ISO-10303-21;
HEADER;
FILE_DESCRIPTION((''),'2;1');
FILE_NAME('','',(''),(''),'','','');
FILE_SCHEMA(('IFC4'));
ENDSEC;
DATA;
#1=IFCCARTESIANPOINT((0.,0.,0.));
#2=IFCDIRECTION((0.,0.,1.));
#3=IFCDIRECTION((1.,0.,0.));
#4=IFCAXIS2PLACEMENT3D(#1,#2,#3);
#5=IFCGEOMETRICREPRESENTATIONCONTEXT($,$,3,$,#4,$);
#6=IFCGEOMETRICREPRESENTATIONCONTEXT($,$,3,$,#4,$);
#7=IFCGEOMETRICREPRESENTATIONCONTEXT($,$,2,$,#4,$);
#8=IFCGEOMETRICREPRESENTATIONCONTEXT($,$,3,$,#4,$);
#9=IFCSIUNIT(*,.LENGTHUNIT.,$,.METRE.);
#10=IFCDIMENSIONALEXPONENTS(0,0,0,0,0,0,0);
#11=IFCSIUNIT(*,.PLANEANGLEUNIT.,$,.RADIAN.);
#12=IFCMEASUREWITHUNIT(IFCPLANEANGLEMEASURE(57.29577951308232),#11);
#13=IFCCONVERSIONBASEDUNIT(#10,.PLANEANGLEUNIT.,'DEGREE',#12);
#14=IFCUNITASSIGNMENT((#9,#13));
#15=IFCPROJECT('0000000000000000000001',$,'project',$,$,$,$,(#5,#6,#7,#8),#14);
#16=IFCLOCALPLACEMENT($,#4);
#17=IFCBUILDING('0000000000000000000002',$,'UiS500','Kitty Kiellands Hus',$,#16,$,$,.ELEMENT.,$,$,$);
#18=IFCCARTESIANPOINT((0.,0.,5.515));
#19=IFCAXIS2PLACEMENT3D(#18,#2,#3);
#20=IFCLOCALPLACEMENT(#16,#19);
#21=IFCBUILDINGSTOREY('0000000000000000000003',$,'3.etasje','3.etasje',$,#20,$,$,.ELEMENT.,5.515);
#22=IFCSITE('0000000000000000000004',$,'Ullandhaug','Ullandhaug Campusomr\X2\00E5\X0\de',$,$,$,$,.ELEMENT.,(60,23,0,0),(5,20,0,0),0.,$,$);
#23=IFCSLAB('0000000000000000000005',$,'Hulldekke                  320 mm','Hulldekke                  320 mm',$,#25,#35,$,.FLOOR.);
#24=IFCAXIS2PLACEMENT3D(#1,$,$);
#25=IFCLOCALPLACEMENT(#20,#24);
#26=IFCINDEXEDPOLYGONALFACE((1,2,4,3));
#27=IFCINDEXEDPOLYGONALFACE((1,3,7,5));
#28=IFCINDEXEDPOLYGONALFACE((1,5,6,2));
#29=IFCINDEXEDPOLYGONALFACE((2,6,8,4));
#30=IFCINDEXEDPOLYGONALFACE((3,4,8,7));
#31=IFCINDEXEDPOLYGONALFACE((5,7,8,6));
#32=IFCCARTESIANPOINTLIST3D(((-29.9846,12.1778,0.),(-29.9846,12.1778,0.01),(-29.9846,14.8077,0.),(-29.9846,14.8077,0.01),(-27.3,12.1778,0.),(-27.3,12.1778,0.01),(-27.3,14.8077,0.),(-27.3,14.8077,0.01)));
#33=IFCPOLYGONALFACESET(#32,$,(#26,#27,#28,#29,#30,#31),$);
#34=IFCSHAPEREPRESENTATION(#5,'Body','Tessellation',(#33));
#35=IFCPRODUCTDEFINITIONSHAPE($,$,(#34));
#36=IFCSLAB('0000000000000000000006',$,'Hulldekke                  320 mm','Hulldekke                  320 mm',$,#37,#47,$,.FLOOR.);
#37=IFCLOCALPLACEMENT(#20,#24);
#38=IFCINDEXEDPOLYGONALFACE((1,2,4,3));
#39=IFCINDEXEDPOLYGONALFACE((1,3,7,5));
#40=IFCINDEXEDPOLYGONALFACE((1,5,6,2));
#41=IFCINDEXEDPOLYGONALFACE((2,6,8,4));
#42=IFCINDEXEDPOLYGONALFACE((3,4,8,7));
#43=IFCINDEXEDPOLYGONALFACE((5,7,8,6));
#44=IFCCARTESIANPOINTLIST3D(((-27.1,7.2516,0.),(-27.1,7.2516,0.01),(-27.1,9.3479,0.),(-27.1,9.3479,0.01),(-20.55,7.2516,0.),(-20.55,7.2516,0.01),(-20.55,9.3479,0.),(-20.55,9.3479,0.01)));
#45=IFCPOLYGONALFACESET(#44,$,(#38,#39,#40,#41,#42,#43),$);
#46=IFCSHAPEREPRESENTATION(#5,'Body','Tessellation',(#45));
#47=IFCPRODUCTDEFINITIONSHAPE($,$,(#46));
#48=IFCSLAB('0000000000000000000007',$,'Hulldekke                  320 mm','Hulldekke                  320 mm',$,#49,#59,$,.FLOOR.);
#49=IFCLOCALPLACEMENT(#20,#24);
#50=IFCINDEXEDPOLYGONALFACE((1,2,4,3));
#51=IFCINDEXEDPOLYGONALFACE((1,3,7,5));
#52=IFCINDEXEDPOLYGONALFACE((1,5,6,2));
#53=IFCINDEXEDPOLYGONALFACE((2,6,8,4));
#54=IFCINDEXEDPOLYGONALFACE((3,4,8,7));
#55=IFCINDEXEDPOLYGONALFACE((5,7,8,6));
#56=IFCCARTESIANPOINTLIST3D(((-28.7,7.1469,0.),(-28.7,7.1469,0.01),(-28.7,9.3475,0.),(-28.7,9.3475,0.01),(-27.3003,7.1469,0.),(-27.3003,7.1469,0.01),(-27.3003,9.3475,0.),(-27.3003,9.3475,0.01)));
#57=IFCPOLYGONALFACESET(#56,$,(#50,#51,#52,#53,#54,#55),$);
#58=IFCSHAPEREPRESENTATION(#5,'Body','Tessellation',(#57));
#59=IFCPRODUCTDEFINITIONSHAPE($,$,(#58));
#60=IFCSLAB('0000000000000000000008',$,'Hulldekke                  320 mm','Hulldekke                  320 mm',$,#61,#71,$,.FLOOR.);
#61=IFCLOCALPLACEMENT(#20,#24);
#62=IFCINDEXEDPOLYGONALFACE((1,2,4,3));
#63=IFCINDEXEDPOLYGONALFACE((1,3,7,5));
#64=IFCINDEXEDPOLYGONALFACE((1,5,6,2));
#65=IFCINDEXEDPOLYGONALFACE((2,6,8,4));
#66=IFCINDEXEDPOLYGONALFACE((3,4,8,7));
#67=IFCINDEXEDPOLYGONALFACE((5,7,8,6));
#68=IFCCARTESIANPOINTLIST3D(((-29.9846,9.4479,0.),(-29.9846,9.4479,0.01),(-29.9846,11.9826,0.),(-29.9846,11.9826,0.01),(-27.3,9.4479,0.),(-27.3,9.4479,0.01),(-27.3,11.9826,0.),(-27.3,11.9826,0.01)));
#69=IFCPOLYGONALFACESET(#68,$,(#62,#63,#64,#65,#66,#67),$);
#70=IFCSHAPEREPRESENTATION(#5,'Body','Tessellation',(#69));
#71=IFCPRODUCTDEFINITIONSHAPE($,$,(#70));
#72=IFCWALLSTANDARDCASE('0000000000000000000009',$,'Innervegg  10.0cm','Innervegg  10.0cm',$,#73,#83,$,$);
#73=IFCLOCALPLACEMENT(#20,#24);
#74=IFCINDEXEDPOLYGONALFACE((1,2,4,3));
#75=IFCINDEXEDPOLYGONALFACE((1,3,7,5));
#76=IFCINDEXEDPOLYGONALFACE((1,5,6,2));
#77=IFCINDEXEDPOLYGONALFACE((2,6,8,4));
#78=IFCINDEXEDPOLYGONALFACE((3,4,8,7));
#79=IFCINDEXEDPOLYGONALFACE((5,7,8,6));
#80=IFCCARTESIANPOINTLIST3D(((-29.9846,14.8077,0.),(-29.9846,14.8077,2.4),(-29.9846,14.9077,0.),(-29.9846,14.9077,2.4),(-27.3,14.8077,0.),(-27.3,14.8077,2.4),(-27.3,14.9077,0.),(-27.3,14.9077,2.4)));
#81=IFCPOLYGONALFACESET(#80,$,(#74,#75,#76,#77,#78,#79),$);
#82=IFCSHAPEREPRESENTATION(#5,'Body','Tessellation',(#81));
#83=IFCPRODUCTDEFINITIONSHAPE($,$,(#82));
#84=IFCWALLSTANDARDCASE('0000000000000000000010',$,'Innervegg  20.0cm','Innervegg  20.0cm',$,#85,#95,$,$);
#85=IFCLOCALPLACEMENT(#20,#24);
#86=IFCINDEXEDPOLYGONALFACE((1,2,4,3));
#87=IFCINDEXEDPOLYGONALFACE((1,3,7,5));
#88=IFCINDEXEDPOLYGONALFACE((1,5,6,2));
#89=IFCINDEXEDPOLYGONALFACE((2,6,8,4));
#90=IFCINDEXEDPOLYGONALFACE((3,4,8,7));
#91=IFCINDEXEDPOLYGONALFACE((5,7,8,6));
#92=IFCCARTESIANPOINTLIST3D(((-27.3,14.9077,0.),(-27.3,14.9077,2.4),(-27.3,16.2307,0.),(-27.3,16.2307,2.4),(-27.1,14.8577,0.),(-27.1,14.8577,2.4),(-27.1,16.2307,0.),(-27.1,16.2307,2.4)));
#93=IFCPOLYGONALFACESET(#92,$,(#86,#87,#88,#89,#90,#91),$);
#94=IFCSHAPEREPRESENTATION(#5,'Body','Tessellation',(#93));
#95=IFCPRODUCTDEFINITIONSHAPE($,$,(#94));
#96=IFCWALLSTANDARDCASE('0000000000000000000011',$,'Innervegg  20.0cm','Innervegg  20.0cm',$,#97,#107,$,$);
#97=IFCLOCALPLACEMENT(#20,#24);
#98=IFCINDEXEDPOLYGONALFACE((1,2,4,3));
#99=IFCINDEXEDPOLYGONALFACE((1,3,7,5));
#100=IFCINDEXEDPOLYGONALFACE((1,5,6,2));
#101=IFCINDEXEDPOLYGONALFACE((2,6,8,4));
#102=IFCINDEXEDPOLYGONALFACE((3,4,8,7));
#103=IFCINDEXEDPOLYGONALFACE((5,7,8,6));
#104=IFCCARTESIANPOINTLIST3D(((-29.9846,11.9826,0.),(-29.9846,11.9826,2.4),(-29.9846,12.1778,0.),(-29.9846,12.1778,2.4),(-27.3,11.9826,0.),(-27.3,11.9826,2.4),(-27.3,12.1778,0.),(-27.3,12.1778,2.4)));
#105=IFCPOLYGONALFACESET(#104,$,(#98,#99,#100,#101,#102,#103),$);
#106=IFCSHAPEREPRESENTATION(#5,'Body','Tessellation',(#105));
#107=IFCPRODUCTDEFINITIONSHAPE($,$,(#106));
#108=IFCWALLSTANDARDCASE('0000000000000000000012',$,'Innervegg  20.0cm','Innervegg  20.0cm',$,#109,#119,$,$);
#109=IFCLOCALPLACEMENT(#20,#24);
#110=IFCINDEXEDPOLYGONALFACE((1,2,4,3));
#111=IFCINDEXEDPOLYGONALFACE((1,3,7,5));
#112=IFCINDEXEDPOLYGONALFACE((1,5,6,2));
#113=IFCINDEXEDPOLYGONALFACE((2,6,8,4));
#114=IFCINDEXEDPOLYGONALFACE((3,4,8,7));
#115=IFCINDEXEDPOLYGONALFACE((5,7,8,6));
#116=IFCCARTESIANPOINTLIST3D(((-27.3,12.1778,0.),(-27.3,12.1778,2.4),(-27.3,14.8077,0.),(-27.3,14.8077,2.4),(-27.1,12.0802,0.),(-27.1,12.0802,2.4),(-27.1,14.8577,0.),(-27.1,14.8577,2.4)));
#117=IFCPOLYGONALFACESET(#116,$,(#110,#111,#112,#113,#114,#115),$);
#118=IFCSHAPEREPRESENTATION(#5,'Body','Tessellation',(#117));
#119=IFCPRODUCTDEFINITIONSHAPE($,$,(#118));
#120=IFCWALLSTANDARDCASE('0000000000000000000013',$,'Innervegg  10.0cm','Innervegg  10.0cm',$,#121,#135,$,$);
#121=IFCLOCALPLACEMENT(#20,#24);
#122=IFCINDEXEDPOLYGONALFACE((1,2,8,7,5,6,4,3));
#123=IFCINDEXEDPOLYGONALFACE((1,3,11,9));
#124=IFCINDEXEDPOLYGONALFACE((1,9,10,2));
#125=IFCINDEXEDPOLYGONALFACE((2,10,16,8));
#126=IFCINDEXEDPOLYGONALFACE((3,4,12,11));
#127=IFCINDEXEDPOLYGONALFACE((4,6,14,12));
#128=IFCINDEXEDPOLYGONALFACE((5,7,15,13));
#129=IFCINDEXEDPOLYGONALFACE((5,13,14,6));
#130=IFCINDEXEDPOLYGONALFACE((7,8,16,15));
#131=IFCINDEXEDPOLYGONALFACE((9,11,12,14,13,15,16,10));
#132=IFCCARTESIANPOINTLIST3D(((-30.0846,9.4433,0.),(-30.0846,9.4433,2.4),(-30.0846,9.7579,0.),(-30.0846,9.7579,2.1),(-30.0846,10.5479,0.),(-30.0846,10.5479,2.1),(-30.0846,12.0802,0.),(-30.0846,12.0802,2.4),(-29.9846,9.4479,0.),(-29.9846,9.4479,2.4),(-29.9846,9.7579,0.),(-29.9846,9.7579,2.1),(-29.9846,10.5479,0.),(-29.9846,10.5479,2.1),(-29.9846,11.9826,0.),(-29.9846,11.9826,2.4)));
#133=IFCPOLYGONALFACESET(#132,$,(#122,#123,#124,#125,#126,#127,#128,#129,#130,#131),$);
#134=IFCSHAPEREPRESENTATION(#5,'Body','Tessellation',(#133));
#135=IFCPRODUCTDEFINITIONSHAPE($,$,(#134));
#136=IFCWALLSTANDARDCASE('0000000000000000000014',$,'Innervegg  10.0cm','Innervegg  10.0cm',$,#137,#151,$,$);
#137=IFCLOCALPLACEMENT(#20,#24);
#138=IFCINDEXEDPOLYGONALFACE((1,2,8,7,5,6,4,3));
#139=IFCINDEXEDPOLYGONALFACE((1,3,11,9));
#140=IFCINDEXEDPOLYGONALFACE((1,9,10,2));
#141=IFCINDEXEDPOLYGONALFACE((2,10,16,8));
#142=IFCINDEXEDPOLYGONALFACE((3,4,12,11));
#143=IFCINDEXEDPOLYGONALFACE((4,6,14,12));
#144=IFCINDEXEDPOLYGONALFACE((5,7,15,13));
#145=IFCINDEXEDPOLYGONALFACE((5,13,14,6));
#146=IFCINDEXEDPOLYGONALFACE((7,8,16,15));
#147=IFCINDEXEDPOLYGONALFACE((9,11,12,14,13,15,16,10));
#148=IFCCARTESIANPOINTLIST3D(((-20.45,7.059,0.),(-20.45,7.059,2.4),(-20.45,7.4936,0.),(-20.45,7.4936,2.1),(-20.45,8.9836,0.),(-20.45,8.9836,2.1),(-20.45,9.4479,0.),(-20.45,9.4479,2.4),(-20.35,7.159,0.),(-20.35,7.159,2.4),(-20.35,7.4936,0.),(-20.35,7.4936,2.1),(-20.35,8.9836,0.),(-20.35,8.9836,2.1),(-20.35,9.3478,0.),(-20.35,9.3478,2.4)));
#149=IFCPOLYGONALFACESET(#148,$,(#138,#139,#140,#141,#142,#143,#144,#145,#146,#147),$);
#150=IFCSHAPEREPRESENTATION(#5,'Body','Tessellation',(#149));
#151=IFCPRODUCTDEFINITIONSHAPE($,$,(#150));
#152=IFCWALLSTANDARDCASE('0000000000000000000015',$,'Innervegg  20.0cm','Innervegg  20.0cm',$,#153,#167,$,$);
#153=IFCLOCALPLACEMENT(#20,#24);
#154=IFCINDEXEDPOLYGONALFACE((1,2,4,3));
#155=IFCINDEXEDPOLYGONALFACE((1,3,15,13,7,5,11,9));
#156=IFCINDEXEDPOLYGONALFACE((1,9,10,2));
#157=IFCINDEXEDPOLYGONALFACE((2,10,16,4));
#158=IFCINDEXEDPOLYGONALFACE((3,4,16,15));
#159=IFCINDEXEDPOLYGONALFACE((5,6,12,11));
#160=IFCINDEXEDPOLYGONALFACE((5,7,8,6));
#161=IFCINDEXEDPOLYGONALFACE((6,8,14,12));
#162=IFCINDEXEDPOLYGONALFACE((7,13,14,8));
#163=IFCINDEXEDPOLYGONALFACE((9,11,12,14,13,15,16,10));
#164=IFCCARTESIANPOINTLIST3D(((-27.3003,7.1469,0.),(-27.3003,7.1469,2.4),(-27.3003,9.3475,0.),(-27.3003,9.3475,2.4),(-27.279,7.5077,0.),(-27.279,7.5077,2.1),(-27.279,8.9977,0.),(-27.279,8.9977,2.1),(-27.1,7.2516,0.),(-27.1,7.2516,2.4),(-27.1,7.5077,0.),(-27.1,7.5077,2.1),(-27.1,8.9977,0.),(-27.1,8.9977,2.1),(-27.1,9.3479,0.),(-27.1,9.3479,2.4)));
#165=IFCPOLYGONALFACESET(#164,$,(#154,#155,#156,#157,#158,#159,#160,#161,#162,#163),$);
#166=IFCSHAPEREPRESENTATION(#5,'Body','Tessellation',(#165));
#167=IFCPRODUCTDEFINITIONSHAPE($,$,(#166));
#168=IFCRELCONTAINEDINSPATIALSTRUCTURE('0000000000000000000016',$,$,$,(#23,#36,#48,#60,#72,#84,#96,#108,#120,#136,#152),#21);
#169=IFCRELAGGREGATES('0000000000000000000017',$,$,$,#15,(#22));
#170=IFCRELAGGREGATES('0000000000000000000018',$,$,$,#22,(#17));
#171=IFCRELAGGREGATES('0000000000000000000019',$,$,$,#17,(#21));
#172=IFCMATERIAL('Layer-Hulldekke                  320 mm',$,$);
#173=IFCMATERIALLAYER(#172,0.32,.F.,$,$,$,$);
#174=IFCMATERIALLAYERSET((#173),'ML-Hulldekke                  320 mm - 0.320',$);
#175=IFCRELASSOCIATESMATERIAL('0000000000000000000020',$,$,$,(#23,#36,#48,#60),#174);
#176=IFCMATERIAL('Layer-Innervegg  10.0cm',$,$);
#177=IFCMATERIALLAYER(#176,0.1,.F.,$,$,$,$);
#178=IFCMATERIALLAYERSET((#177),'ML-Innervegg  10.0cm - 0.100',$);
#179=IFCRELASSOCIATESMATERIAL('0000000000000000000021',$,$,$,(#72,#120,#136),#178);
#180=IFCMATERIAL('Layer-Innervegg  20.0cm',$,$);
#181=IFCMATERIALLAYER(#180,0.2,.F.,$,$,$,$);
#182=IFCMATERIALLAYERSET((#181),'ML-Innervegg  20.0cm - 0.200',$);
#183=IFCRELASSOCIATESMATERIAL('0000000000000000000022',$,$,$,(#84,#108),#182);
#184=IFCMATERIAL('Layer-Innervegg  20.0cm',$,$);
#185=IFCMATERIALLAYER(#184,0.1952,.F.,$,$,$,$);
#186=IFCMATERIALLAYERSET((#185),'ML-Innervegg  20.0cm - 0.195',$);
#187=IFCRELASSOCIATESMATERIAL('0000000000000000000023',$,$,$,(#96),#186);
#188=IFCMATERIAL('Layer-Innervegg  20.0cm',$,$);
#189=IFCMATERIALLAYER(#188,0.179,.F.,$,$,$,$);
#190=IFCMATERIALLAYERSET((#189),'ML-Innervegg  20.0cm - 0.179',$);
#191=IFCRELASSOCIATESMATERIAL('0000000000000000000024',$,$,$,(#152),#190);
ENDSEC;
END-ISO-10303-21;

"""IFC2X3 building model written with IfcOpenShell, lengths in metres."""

from ifc_helpers import new_model, entity, si_unit, converted_unit, frame, origin_with_axes, place, context, project, spatial, polyline, outline, extrude, material, layer, layer_set, layer_usage, element, save


model = new_model("IFC2X3")

# Units and contexts
context_of_model_1 = context(None, 3, world=origin_with_axes())
context_of_model_2 = context(None, 3, world=origin_with_axes())
context_of_model_3 = context(None, 2, world=origin_with_axes())
context_of_model_4 = context(None, 3, world=origin_with_axes())
ifc_project = project(units=[si_unit("LENGTHUNIT", "METRE"), converted_unit("PLANEANGLEUNIT", "DEGREE", entity("IfcPlaneAngleMeasure", 57.29577951308232), si_unit("PLANEANGLEUNIT", "RADIAN"), dimensions=[0, 0, 0, 0, 0, 0, 0])], contexts=[context_of_model_1, context_of_model_2, context_of_model_3, context_of_model_4])

# Site, building, storey
site = spatial("IfcSite", under=ifc_project, Name="Ullandhaug", Description="Ullandhaug Campusområde", CompositionType="ELEMENT", RefLatitude=(60, 23, 0, 0), RefLongitude=(5, 20, 0, 0), RefElevation=0.0)
building_placement = place(None, origin_with_axes())
building = spatial("IfcBuilding", under=site, at=building_placement, Name="UiS500", Description="Kitty Kiellands Hus", CompositionType="ELEMENT")
storey_placement = place(building_placement, frame((0.0, 0.0, 5.515), z_axis=(0.0, 0.0, 1.0), x_axis=(1.0, 0.0, 0.0)))
storey = spatial("IfcBuildingStorey", under=building, at=storey_placement, Name="3.etasje", Description="3.etasje", CompositionType="ELEMENT", Elevation=5.515)

# Slabs
ifc_material_1 = material(Name="Layer-Hulldekke                  320 mm")
ifc_layer_1 = layer(ifc_material_1, 0.32, ventilated=False)
ifc_layer_set_1 = layer_set([ifc_layer_1], Name="ML-Hulldekke                  320 mm - 0.320")
ifc_layer_usage_1 = layer_usage(ifc_layer_set_1, "AXIS2", "POSITIVE", 0.0)
slab_1_placement = place(storey_placement, frame((-29.9846, 14.8077, 0.0), z_axis=(0.0, 0.0, 1.0), x_axis=(1.0, 0.0, 0.0)))
element("IfcSlab", 1, at=slab_1_placement, inside=storey, material=ifc_layer_usage_1, Name="Hulldekke                  320 mm", Description="Hulldekke                  320 mm", PredefinedType="FLOOR", context=context_of_model_1, shape_type="SweptSolid", body=[
    extrude(outline(polyline([(0.0, 0.0), (2.6299, 0.0), (2.6299, 2.6846), (0.0, 2.6846), (0.0, 0.0)])), frame((0.0, 0.0, 0.0), z_axis=(0.0, 0.0, 1.0), x_axis=(0.0, -1.0, 0.0)), (0.0, 0.0, 1.0), 0.01),
])
slab_2_placement = place(storey_placement, frame((-27.1, 9.3479, 0.0), z_axis=(0.0, 0.0, 1.0), x_axis=(1.0, 0.0, 0.0)))
element("IfcSlab", 2, at=slab_2_placement, inside=storey, material=ifc_layer_usage_1, Name="Hulldekke                  320 mm", Description="Hulldekke                  320 mm", PredefinedType="FLOOR", context=context_of_model_1, shape_type="SweptSolid", body=[
    extrude(outline(polyline([(0.0, 0.0), (2.0963, 0.0), (2.0963, 6.55), (0.0, 6.55), (0.0, 0.0)])), frame((0.0, 0.0, 0.0), z_axis=(0.0, 0.0, 1.0), x_axis=(0.0, -1.0, 0.0)), (0.0, 0.0, 1.0), 0.01),
])
slab_3_placement = place(storey_placement, frame((-28.7, 9.3475, 0.0), z_axis=(0.0, 0.0, 1.0), x_axis=(1.0, 0.0, 0.0)))
element("IfcSlab", 3, at=slab_3_placement, inside=storey, material=ifc_layer_usage_1, Name="Hulldekke                  320 mm", Description="Hulldekke                  320 mm", PredefinedType="FLOOR", context=context_of_model_1, shape_type="SweptSolid", body=[
    extrude(outline(polyline([(0.0, 0.0), (2.2006, 0.0), (2.2006, 1.3997), (0.0, 1.3997), (0.0, 0.0)])), frame((0.0, 0.0, 0.0), z_axis=(0.0, 0.0, 1.0), x_axis=(0.0, -1.0, 0.0)), (0.0, 0.0, 1.0), 0.01),
])
slab_4_placement = place(storey_placement, frame((-29.9846, 11.9826, 0.0), z_axis=(0.0, 0.0, 1.0), x_axis=(1.0, 0.0, 0.0)))
element("IfcSlab", 4, at=slab_4_placement, inside=storey, material=ifc_layer_usage_1, Name="Hulldekke                  320 mm", Description="Hulldekke                  320 mm", PredefinedType="FLOOR", context=context_of_model_1, shape_type="SweptSolid", body=[
    extrude(outline(polyline([(0.0, 0.0), (2.5347, 0.0), (2.5347, 2.6846), (0.0, 2.6846), (0.0, 0.0)])), frame((0.0, 0.0, 0.0), z_axis=(0.0, 0.0, 1.0), x_axis=(0.0, -1.0, 0.0)), (0.0, 0.0, 1.0), 0.01),
])

# Walls
ifc_material_2 = material(Name="Layer-Innervegg  10.0cm")
ifc_layer_2 = layer(ifc_material_2, 0.1, ventilated=False)
ifc_layer_set_2 = layer_set([ifc_layer_2], Name="ML-Innervegg  10.0cm - 0.100")
ifc_layer_usage_2 = layer_usage(ifc_layer_set_2, "AXIS2", "POSITIVE", 0.0)
wall_1_placement = place(storey_placement, frame((-29.9846, 14.8077, 0.0), z_axis=(0.0, 0.0, 1.0), x_axis=(1.0, 0.0, 0.0)))
element("IfcWallStandardCase", 5, at=wall_1_placement, inside=storey, material=ifc_layer_usage_2, Name="Innervegg  10.0cm", Description="Innervegg  10.0cm", context=context_of_model_1, shape_type="SweptSolid", body=[
    extrude(outline(polyline([(0.0, 0.0), (2.6846, 0.0), (2.6846, 0.1), (0.0, 0.1), (0.0, 0.0)])), origin_with_axes(), (0.0, 0.0, 1.0), 2.4),
])
ifc_material_3 = material(Name="Layer-Innervegg  20.0cm")
ifc_layer_3 = layer(ifc_material_3, 0.2, ventilated=False)
ifc_layer_set_3 = layer_set([ifc_layer_3], Name="ML-Innervegg  20.0cm - 0.200")
ifc_layer_usage_3 = layer_usage(ifc_layer_set_3, "AXIS2", "POSITIVE", 0.0)
wall_2_placement = place(storey_placement, frame((-27.1, 14.8577, 0.0), z_axis=(0.0, 0.0, 1.0), x_axis=(0.0, 1.0, 0.0)))
element("IfcWallStandardCase", 6, at=wall_2_placement, inside=storey, material=ifc_layer_usage_3, Name="Innervegg  20.0cm", Description="Innervegg  20.0cm", context=context_of_model_1, shape_type="SweptSolid", body=[
    extrude(outline(polyline([(0.0, 0.0), (1.373, 0.0), (1.373, 0.2), (0.05, 0.2), (0.0, 0.0)])), frame((0.0, 0.0, 0.0), z_axis=(0.0, 0.0, 1.0), x_axis=(1.0, 0.0, 0.0)), (0.0, 0.0, 1.0), 2.4),
])
ifc_material_4 = material(Name="Layer-Innervegg  20.0cm")
ifc_layer_4 = layer(ifc_material_4, 0.1952, ventilated=False)
ifc_layer_set_4 = layer_set([ifc_layer_4], Name="ML-Innervegg  20.0cm - 0.195")
ifc_layer_usage_4 = layer_usage(ifc_layer_set_4, "AXIS2", "POSITIVE", 0.0)
wall_3_placement = place(storey_placement, frame((-29.9846, 11.9826, 0.0), z_axis=(0.0, 0.0, 1.0), x_axis=(1.0, 0.0, 0.0)))
element("IfcWallStandardCase", 7, at=wall_3_placement, inside=storey, material=ifc_layer_usage_4, Name="Innervegg  20.0cm", Description="Innervegg  20.0cm", context=context_of_model_1, shape_type="SweptSolid", body=[
    extrude(outline(polyline([(0.0, 0.0), (2.6846, 0.0), (2.6846, 0.1952), (0.0, 0.1952), (0.0, 0.0)])), origin_with_axes(), (0.0, 0.0, 1.0), 2.4),
])
wall_4_placement = place(storey_placement, frame((-27.1, 12.0802, 0.0), z_axis=(0.0, 0.0, 1.0), x_axis=(0.0, 1.0, 0.0)))
element("IfcWallStandardCase", 8, at=wall_4_placement, inside=storey, material=ifc_layer_usage_3, Name="Innervegg  20.0cm", Description="Innervegg  20.0cm", context=context_of_model_1, shape_type="SweptSolid", body=[
    extrude(outline(polyline([(0.0, 0.0), (2.7775, 0.0), (2.7275, 0.2), (0.0976, 0.2), (0.0, 0.0)])), frame((0.0, 0.0, 0.0), z_axis=(0.0, 0.0, 1.0), x_axis=(1.0, 0.0, 0.0)), (0.0, 0.0, 1.0), 2.4),
])

# Walls, openings
wall_5_placement = place(storey_placement, frame((-29.9846, 9.4479, 0.0), z_axis=(0.0, 0.0, 1.0), x_axis=(0.0, 1.0, 0.0)))
wall_5 = element("IfcWallStandardCase", 9, at=wall_5_placement, inside=storey, material=ifc_layer_usage_2, Name="Innervegg  10.0cm", Description="Innervegg  10.0cm", context=context_of_model_1, shape_type="SweptSolid", body=[
    extrude(outline(polyline([(0.0, 0.0), (2.5347, 0.0), (2.6323, 0.1), (-0.0047, 0.1), (0.0, 0.0)])), frame((0.0, 0.0, 0.0), z_axis=(0.0, 0.0, 1.0), x_axis=(1.0, 0.0, 0.0)), (0.0, 0.0, 1.0), 2.4),
])
opening_1_placement = place(wall_5_placement, frame((0.3099, 0.1, 0.0), z_axis=(0.0, 0.0, 1.0), x_axis=(1.0, 0.0, 0.0)))
element("IfcOpeningElement", 10, at=opening_1_placement, cuts=wall_5, context=context_of_model_1, shape_type="SweptSolid", body=[
    extrude(outline(polyline([(0.0, 0.0), (2.1, 0.0), (2.1, 0.79), (0.0, 0.79), (0.0, 0.0)])), frame((0.0, 0.0, 0.0), z_axis=(0.0, 1.0, 0.0), x_axis=(0.0, 0.0, 1.0)), (0.0, 0.0, -1.0), 0.1),
])
wall_6_placement = place(storey_placement, frame((-20.45, 9.4479, 0.0), z_axis=(0.0, 0.0, 1.0), x_axis=(0.0, -1.0, 0.0)))
wall_6 = element("IfcWallStandardCase", 11, at=wall_6_placement, inside=storey, material=ifc_layer_usage_2, Name="Innervegg  10.0cm", Description="Innervegg  10.0cm", context=context_of_model_1, shape_type="SweptSolid", body=[
    extrude(outline(polyline([(0.0, 0.0), (2.3889, 0.0), (2.2889, 0.1), (0.1002, 0.1), (0.0, 0.0)])), frame((0.0, 0.0, 0.0), z_axis=(0.0, 0.0, 1.0), x_axis=(1.0, 0.0, 0.0)), (0.0, 0.0, 1.0), 2.4),
])
opening_2_placement = place(wall_6_placement, frame((0.4644, 0.1, 0.0), z_axis=(0.0, 0.0, 1.0), x_axis=(1.0, 0.0, 0.0)))
element("IfcOpeningElement", 12, at=opening_2_placement, cuts=wall_6, context=context_of_model_1, shape_type="SweptSolid", body=[
    extrude(outline(polyline([(0.0, 0.0), (2.1, 0.0), (2.1, 1.49), (0.0, 1.49), (0.0, 0.0)])), frame((0.0, 0.0, 0.0), z_axis=(0.0, 1.0, 0.0), x_axis=(0.0, 0.0, 1.0)), (0.0, 0.0, -1.0), 0.1),
])
ifc_material_5 = material(Name="Layer-Innervegg  20.0cm")
ifc_layer_5 = layer(ifc_material_5, 0.179, ventilated=False)
ifc_layer_set_5 = layer_set([ifc_layer_5], Name="ML-Innervegg  20.0cm - 0.179")
ifc_layer_usage_5 = layer_usage(ifc_layer_set_5, "AXIS2", "POSITIVE", 0.0)
wall_7_placement = place(storey_placement, frame((-27.3003, 9.3475, 0.0), z_axis=(0.0, 0.0, 1.0), x_axis=(0.0, -1.0, 0.0)))
wall_7 = element("IfcWallStandardCase", 13, at=wall_7_placement, inside=storey, material=ifc_layer_usage_5, Name="Innervegg  20.0cm", Description="Innervegg  20.0cm", context=context_of_model_1, shape_type="SweptSolid", body=[
    extrude(outline(polyline([(0.0, 0.0), (2.2006, 0.0), (2.0959, 0.2003), (-0.0004, 0.2003), (0.0, 0.0)])), frame((0.0, 0.0, 0.0), z_axis=(0.0, 0.0, 1.0), x_axis=(1.0, 0.0, 0.0)), (0.0, 0.0, 1.0), 2.4),
])
opening_3_placement = place(wall_7_placement, frame((0.3498, 0.2003, 0.0), z_axis=(0.0, 0.0, 1.0), x_axis=(1.0, 0.0, 0.0)))
element("IfcOpeningElement", 14, at=opening_3_placement, cuts=wall_7, context=context_of_model_1, shape_type="SweptSolid", body=[
    extrude(outline(polyline([(0.0, 0.0), (2.1, 0.0), (2.1, 1.49), (0.0, 1.49), (0.0, 0.0)])), frame((0.0, 0.0, 0.0), z_axis=(0.0, 1.0, 0.0), x_axis=(0.0, 0.0, 1.0)), (0.0, 0.0, -1.0), 0.179),
])

save(model, "model.ifc")
